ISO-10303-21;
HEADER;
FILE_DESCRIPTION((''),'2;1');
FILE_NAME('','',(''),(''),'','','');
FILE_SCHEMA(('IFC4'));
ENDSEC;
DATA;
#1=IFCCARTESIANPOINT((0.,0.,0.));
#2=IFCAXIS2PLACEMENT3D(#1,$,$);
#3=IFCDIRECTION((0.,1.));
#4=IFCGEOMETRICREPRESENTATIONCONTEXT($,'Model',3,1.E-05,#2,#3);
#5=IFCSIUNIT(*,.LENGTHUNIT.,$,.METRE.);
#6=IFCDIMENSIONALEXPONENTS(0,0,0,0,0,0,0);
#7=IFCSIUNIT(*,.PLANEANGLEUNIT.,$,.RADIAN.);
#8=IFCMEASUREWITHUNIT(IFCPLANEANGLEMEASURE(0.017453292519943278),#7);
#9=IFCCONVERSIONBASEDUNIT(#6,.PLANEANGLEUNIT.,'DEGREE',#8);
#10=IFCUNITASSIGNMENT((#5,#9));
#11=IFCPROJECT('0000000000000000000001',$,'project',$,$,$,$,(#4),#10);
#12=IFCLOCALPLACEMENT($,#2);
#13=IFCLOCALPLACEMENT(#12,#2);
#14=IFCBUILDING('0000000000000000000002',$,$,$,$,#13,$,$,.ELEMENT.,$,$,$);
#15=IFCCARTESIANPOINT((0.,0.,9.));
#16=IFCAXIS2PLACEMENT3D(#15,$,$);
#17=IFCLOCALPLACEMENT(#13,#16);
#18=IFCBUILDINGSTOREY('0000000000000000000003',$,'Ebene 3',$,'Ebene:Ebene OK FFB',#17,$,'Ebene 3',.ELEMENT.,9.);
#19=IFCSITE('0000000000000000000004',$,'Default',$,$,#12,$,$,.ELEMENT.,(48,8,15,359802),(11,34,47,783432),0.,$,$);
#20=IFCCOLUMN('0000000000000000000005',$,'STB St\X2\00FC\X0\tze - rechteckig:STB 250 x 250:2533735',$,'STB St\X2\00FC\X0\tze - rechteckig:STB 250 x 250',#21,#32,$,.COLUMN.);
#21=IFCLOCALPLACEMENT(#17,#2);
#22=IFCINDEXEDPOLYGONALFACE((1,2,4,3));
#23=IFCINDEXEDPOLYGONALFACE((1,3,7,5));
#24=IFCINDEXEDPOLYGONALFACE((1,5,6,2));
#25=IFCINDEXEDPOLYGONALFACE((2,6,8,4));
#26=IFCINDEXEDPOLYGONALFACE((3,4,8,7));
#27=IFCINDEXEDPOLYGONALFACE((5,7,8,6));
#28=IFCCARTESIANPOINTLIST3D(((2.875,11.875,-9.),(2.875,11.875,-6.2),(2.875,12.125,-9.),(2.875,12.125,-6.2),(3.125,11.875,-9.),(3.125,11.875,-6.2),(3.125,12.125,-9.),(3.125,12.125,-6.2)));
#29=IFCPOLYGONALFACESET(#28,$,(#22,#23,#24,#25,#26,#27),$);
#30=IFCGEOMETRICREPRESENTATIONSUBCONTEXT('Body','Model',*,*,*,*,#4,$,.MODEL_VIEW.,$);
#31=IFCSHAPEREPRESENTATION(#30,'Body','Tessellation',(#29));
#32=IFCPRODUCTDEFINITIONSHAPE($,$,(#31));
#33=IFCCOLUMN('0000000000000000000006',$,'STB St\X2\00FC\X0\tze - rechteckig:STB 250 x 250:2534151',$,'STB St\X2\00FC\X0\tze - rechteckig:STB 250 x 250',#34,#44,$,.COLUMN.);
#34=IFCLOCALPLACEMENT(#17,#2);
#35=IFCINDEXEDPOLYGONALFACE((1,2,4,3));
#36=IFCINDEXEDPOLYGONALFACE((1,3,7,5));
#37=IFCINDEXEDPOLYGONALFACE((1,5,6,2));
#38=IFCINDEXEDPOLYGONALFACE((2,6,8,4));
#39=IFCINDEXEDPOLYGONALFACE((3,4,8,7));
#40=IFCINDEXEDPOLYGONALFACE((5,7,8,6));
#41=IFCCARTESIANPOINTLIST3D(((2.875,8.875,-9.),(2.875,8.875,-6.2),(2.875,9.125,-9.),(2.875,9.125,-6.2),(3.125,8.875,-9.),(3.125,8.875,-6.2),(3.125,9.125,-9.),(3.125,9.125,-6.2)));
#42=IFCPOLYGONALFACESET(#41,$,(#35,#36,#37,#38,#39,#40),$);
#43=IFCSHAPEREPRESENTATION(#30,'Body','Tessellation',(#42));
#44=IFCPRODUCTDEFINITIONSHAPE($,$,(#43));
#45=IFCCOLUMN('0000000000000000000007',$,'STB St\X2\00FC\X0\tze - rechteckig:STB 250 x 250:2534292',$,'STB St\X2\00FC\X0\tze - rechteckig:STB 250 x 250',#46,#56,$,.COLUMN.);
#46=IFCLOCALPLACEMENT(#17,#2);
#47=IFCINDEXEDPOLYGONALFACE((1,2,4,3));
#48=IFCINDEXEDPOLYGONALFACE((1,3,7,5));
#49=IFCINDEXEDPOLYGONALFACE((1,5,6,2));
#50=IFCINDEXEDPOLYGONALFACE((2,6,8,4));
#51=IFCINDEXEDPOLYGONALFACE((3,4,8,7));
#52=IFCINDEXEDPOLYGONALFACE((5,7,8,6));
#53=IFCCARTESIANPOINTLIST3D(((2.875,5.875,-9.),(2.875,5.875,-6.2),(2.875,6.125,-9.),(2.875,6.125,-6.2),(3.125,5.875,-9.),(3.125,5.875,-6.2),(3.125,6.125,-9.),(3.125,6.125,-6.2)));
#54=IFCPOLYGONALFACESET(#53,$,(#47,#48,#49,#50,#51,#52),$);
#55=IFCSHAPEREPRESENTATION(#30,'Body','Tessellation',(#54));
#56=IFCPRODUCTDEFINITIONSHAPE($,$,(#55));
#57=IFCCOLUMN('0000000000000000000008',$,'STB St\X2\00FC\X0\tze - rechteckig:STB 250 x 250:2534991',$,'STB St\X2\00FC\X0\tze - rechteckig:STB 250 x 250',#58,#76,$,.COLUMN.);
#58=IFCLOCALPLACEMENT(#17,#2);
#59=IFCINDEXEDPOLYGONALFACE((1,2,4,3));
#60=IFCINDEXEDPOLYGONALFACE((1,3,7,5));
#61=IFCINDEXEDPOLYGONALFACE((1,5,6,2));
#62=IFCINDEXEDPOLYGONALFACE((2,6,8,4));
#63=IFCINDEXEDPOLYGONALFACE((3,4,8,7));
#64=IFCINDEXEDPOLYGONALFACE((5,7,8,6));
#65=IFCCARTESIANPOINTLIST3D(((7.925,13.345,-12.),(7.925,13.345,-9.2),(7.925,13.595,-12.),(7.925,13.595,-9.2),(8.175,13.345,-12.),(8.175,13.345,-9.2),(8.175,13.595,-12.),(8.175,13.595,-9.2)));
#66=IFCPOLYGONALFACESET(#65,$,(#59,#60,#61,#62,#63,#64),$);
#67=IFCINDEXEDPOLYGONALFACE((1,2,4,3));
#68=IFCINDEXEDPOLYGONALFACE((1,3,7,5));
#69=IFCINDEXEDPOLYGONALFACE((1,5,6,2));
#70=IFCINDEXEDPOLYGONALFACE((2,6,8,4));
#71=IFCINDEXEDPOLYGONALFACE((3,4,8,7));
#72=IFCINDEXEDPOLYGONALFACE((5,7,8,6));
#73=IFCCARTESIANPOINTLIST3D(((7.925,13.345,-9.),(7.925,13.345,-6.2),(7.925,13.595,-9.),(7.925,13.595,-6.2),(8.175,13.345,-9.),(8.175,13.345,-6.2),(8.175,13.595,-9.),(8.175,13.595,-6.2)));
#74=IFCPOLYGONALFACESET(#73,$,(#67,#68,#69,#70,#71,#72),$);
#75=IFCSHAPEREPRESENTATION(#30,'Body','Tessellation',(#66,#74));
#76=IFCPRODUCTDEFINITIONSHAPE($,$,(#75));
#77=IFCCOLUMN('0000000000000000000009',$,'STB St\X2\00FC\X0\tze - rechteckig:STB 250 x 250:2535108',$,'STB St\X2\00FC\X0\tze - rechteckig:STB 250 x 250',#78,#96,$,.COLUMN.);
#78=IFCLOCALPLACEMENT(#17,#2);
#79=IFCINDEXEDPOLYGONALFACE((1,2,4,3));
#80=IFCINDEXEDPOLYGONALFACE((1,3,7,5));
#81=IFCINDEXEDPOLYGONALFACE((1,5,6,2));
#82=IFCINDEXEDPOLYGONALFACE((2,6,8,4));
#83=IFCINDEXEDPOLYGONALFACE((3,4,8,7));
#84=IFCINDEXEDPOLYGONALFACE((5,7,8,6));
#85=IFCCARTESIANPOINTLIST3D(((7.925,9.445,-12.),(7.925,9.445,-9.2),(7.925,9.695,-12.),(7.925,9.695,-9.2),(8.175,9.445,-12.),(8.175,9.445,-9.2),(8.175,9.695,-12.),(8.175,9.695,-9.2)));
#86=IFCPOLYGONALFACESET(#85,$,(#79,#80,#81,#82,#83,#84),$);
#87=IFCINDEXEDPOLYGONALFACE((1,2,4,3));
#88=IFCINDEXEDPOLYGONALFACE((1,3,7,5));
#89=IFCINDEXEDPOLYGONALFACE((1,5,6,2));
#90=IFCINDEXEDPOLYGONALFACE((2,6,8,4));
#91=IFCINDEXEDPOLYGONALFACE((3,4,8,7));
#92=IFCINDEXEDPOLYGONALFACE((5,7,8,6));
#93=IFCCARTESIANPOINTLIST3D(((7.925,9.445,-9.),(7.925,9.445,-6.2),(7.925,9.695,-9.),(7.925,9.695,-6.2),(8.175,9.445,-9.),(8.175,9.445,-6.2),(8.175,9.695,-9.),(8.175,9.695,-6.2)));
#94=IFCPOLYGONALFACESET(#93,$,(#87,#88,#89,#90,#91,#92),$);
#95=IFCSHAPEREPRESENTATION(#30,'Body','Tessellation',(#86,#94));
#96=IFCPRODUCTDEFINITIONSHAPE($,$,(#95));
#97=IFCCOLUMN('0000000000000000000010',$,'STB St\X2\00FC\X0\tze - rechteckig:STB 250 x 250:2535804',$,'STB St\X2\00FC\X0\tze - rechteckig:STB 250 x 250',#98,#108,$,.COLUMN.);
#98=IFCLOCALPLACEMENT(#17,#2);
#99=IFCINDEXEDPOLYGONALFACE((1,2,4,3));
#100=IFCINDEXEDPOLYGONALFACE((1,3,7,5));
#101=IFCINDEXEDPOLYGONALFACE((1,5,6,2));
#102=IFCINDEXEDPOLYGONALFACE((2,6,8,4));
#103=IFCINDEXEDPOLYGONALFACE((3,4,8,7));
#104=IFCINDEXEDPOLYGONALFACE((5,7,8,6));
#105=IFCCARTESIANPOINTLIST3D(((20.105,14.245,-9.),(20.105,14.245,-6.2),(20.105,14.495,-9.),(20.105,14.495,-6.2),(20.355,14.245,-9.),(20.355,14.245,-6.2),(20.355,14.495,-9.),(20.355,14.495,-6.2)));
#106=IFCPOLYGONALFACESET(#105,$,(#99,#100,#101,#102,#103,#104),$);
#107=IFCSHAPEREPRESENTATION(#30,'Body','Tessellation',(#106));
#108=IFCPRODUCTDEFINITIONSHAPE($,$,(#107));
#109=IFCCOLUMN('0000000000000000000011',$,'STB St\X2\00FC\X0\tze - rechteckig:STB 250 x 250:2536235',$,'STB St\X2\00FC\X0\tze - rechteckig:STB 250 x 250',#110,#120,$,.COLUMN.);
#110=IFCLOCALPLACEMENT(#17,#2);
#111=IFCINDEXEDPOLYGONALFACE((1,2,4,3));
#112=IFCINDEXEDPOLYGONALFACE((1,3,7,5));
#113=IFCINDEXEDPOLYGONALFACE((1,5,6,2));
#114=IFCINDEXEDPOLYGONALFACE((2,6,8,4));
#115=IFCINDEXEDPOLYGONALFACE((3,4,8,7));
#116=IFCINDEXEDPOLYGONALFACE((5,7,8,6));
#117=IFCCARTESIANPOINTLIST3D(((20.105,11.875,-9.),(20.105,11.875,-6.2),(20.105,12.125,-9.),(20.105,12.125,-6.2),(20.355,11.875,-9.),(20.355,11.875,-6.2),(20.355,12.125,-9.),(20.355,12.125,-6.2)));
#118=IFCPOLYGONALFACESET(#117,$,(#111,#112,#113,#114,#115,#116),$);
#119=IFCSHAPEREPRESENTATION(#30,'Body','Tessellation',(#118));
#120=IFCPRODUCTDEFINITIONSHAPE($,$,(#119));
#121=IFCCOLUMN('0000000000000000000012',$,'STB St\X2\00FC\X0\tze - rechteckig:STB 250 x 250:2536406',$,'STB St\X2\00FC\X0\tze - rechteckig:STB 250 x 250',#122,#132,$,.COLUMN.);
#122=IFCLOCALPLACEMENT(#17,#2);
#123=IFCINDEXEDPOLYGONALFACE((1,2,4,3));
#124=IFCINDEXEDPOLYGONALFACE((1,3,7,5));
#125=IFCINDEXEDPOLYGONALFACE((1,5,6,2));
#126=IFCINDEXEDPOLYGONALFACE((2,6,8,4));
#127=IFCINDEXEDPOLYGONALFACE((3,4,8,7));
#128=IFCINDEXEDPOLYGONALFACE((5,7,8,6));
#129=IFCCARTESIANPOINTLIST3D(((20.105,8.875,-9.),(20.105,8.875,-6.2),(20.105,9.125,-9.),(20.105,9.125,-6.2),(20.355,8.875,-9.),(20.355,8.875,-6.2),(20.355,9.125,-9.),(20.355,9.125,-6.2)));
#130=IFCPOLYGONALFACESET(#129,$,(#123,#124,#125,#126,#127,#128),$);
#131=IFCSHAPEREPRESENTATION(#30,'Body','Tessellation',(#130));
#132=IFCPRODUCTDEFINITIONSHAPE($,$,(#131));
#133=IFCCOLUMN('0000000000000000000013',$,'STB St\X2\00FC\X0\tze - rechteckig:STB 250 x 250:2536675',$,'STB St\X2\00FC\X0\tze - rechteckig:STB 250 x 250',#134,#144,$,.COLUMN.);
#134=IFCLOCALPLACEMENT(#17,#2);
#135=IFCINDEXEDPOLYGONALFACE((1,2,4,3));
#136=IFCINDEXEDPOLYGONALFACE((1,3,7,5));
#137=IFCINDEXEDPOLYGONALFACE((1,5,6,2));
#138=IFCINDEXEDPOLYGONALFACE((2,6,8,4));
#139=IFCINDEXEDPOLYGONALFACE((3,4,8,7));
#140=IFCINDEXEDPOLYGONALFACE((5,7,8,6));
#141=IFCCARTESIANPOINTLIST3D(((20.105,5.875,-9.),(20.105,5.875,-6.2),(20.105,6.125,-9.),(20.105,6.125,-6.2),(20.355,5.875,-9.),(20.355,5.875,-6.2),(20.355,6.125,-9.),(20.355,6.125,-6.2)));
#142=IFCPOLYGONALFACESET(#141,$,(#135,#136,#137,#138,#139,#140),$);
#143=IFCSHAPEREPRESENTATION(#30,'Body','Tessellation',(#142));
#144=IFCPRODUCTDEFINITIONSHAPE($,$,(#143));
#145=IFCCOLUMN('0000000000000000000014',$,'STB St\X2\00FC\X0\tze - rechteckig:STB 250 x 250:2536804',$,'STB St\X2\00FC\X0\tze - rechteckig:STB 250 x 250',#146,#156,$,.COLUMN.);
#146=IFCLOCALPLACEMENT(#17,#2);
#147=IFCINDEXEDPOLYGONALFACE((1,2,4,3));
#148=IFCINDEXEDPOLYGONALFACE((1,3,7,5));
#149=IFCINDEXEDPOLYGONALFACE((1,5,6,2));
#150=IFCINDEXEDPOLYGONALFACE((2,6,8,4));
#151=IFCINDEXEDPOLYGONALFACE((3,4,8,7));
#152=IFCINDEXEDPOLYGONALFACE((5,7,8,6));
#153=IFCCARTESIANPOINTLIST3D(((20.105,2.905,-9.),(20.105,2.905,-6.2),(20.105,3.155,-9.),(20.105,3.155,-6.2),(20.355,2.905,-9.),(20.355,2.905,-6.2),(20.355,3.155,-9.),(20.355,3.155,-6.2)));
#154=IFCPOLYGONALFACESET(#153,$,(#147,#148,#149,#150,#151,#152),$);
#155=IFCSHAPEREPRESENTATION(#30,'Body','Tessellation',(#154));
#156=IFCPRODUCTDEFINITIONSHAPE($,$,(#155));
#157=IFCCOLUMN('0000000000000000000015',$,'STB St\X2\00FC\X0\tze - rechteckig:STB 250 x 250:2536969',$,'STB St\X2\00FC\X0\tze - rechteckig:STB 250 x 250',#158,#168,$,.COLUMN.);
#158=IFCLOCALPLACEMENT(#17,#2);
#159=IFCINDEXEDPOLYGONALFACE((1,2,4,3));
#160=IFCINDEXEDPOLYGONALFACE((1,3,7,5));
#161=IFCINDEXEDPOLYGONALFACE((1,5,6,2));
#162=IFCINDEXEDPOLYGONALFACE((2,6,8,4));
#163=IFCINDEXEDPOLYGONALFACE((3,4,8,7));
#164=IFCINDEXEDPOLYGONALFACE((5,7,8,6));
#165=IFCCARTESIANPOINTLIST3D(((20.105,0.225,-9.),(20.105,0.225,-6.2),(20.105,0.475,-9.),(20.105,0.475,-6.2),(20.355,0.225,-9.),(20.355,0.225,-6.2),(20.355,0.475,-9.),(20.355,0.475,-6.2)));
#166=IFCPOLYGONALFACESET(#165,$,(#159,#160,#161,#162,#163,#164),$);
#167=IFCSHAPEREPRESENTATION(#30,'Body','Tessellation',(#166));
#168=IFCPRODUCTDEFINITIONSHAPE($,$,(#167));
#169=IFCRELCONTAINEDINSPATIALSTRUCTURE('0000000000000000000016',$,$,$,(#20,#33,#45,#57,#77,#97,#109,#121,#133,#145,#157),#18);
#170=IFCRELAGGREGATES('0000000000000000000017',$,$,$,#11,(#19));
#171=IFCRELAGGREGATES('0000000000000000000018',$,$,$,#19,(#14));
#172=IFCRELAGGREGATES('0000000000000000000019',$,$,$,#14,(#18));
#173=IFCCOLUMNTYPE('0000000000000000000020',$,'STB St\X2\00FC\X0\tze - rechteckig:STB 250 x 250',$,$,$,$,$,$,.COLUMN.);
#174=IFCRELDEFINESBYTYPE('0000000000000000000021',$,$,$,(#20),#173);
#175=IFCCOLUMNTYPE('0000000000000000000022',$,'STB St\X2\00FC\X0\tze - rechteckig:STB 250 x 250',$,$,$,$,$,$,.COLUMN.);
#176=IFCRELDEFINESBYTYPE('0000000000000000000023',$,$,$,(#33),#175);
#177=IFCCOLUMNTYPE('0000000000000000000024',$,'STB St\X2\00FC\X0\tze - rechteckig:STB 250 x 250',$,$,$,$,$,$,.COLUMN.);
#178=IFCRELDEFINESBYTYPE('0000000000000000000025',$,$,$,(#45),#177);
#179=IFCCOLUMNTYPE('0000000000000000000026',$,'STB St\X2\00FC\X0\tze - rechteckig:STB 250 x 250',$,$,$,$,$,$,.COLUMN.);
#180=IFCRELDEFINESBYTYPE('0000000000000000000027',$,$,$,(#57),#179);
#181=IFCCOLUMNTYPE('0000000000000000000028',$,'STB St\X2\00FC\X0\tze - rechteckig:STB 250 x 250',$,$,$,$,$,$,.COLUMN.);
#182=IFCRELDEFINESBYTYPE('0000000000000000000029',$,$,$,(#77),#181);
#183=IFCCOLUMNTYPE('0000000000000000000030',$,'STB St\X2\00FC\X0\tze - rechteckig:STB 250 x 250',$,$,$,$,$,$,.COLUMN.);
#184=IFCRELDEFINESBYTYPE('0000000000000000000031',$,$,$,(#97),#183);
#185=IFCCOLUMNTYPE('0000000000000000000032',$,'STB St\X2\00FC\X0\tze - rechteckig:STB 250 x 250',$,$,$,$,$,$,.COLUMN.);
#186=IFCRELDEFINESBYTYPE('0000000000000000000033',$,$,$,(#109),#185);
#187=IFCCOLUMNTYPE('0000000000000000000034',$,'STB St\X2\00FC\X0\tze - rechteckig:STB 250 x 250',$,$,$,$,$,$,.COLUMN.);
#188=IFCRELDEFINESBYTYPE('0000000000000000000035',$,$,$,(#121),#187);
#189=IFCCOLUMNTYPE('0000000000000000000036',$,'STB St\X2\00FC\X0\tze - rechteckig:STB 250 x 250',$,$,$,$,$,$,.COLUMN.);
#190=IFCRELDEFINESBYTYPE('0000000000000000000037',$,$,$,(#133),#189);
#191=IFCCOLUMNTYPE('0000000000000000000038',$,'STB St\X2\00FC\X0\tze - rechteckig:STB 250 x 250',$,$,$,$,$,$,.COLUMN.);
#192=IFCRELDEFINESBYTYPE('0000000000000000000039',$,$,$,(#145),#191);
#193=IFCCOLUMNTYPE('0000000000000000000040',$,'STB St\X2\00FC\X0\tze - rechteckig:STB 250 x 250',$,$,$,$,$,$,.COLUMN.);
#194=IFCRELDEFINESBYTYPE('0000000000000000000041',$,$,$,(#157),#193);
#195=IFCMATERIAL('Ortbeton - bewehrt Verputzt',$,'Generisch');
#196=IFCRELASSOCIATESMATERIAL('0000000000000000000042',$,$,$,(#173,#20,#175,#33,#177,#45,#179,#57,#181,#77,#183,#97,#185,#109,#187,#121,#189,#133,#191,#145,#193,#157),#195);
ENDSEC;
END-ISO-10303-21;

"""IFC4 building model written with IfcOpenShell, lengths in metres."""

from ifc_helpers import new_model, entity, si_unit, converted_unit, direction, frame, origin, place, context, subcontext, project, spatial, indexed_curve, outline, extrude, source, transform, mapped, material, type_object, type_shapes, element, save


model = new_model("IFC4")

# Units and contexts
model_context = context("Model", 3, precision=1e-05, world=origin(), true_north=direction((0.0, 1.0)))
body_context = subcontext(model_context, "Body", "Model", "MODEL_VIEW")
ifc_project = project(units=[si_unit("LENGTHUNIT", "METRE"), converted_unit("PLANEANGLEUNIT", "DEGREE", entity("IfcPlaneAngleMeasure", 0.017453292519943278), si_unit("PLANEANGLEUNIT", "RADIAN"), dimensions=[0, 0, 0, 0, 0, 0, 0])], contexts=[model_context])

# Site, building, storey
site_placement = place(None, origin())
site = spatial("IfcSite", under=ifc_project, at=site_placement, Name="Default", CompositionType="ELEMENT", RefLatitude=(48, 8, 15, 359802), RefLongitude=(11, 34, 47, 783432), RefElevation=0.0)
building_placement = place(site_placement, origin())
building = spatial("IfcBuilding", under=site, at=building_placement, CompositionType="ELEMENT")
storey_placement = place(building_placement, frame((0.0, 0.0, 9.0)))
storey = spatial("IfcBuildingStorey", under=building, at=storey_placement, Name="Ebene 3", ObjectType="Ebene:Ebene OK FFB", LongName="Ebene 3", CompositionType="ELEMENT", Elevation=9.0)

# Columns
ifc_material_1 = material(Name="Ortbeton - bewehrt Verputzt", Category="Generisch")
column_type_1 = type_object("IfcColumnType", Name="STB Stütze - rechteckig:STB 250 x 250", PredefinedType="COLUMN", material=ifc_material_1)
shared_shape_1 = source(origin(), body_context, "Body", "SweptSolid", [
    extrude(outline(indexed_curve([(-0.125, -0.125), (0.125, -0.125), (0.125, 0.125), (-0.125, 0.125), (-0.125, -0.125)], self_intersect=False)), frame((3.0, 12.0, 0.0), z_axis=(0.0, 0.0, 1.0), x_axis=(-1.0, 0.0, 0.0)), (0.0, 0.0, 1.0), 2.8),
])
type_shapes(column_type_1, [shared_shape_1])
column_1_placement = place(storey_placement, frame((0.0, 0.0, -9.0)))
element("IfcColumn", 1, at=column_1_placement, inside=storey, type_object=column_type_1, material=ifc_material_1, Name="STB Stütze - rechteckig:STB 250 x 250:2533735", ObjectType="STB Stütze - rechteckig:STB 250 x 250", PredefinedType="COLUMN", context=body_context, shape_type="MappedRepresentation", body=[
    mapped(shared_shape_1, transform((0.0, 0.0, 0.0), scale=1.0)),
])
column_type_2 = type_object("IfcColumnType", Name="STB Stütze - rechteckig:STB 250 x 250", PredefinedType="COLUMN", material=ifc_material_1)
shared_shape_2 = source(origin(), body_context, "Body", "SweptSolid", [
    extrude(outline(indexed_curve([(-0.125, -0.125), (0.125, -0.125), (0.125, 0.125), (-0.125, 0.125), (-0.125, -0.125)], self_intersect=False)), frame((3.0, 9.0, 0.0), z_axis=(0.0, 0.0, 1.0), x_axis=(-1.0, 0.0, 0.0)), (0.0, 0.0, 1.0), 2.8),
])
type_shapes(column_type_2, [shared_shape_2])
column_2_placement = place(storey_placement, frame((0.0, 0.0, -9.0)))
element("IfcColumn", 2, at=column_2_placement, inside=storey, type_object=column_type_2, material=ifc_material_1, Name="STB Stütze - rechteckig:STB 250 x 250:2534151", ObjectType="STB Stütze - rechteckig:STB 250 x 250", PredefinedType="COLUMN", context=body_context, shape_type="MappedRepresentation", body=[
    mapped(shared_shape_2, transform((0.0, 0.0, 0.0), scale=1.0)),
])
column_type_3 = type_object("IfcColumnType", Name="STB Stütze - rechteckig:STB 250 x 250", PredefinedType="COLUMN", material=ifc_material_1)
shared_shape_3 = source(origin(), body_context, "Body", "SweptSolid", [
    extrude(outline(indexed_curve([(-0.125, -0.125), (0.125, -0.125), (0.125, 0.125), (-0.125, 0.125), (-0.125, -0.125)], self_intersect=False)), frame((3.0, 6.0, 0.0), z_axis=(0.0, 0.0, 1.0), x_axis=(-1.0, 0.0, 0.0)), (0.0, 0.0, 1.0), 2.8),
])
type_shapes(column_type_3, [shared_shape_3])
column_3_placement = place(storey_placement, frame((0.0, 0.0, -9.0)))
element("IfcColumn", 3, at=column_3_placement, inside=storey, type_object=column_type_3, material=ifc_material_1, Name="STB Stütze - rechteckig:STB 250 x 250:2534292", ObjectType="STB Stütze - rechteckig:STB 250 x 250", PredefinedType="COLUMN", context=body_context, shape_type="MappedRepresentation", body=[
    mapped(shared_shape_3, transform((0.0, 0.0, 0.0), scale=1.0)),
])
column_type_4 = type_object("IfcColumnType", Name="STB Stütze - rechteckig:STB 250 x 250", PredefinedType="COLUMN", material=ifc_material_1)
shared_shape_4 = source(origin(), body_context, "Body", "SweptSolid", [
    extrude(outline(indexed_curve([(-0.125, -0.125), (0.125, -0.125), (0.125, 0.125), (-0.125, 0.125), (-0.125, -0.125)], self_intersect=False)), frame((8.05, 13.47, -3.0), z_axis=(0.0, 0.0, 1.0), x_axis=(-1.0, 0.0, 0.0)), (0.0, 0.0, 1.0), 2.8),
    extrude(outline(indexed_curve([(-0.125, -0.125), (0.125, -0.125), (0.125, 0.125), (-0.125, 0.125), (-0.125, -0.125)], self_intersect=False)), frame((8.05, 13.47, 0.0), z_axis=(0.0, 0.0, 1.0), x_axis=(0.0, -1.0, 0.0)), (0.0, 0.0, 1.0), 2.8),
])
type_shapes(column_type_4, [shared_shape_4])
column_4_placement = place(storey_placement, frame((0.0, 0.0, -9.0)))
element("IfcColumn", 4, at=column_4_placement, inside=storey, type_object=column_type_4, material=ifc_material_1, Name="STB Stütze - rechteckig:STB 250 x 250:2534991", ObjectType="STB Stütze - rechteckig:STB 250 x 250", PredefinedType="COLUMN", context=body_context, shape_type="MappedRepresentation", body=[
    mapped(shared_shape_4, transform((0.0, 0.0, 0.0), scale=1.0)),
])
column_type_5 = type_object("IfcColumnType", Name="STB Stütze - rechteckig:STB 250 x 250", PredefinedType="COLUMN", material=ifc_material_1)
shared_shape_5 = source(origin(), body_context, "Body", "SweptSolid", [
    extrude(outline(indexed_curve([(-0.125, -0.125), (0.125, -0.125), (0.125, 0.125), (-0.125, 0.125), (-0.125, -0.125)], self_intersect=False)), frame((8.05, 9.57, -3.0), z_axis=(0.0, 0.0, 1.0), x_axis=(-1.0, 0.0, 0.0)), (0.0, 0.0, 1.0), 2.8),
    extrude(outline(indexed_curve([(-0.125, -0.125), (0.125, -0.125), (0.125, 0.125), (-0.125, 0.125), (-0.125, -0.125)], self_intersect=False)), frame((8.05, 9.57, 0.0), z_axis=(0.0, 0.0, 1.0), x_axis=(0.0, -1.0, 0.0)), (0.0, 0.0, 1.0), 2.8),
])
type_shapes(column_type_5, [shared_shape_5])
column_5_placement = place(storey_placement, frame((0.0, 0.0, -9.0)))
element("IfcColumn", 5, at=column_5_placement, inside=storey, type_object=column_type_5, material=ifc_material_1, Name="STB Stütze - rechteckig:STB 250 x 250:2535108", ObjectType="STB Stütze - rechteckig:STB 250 x 250", PredefinedType="COLUMN", context=body_context, shape_type="MappedRepresentation", body=[
    mapped(shared_shape_5, transform((0.0, 0.0, 0.0), scale=1.0)),
])
column_type_6 = type_object("IfcColumnType", Name="STB Stütze - rechteckig:STB 250 x 250", PredefinedType="COLUMN", material=ifc_material_1)
shared_shape_6 = source(origin(), body_context, "Body", "SweptSolid", [
    extrude(outline(indexed_curve([(-0.125, -0.125), (0.125, -0.125), (0.125, 0.125), (-0.125, 0.125), (-0.125, -0.125)], self_intersect=False)), frame((20.23, 14.37, 0.0), z_axis=(0.0, 0.0, 1.0), x_axis=(-1.0, 0.0, 0.0)), (0.0, 0.0, 1.0), 2.8),
])
type_shapes(column_type_6, [shared_shape_6])
column_6_placement = place(storey_placement, frame((0.0, 0.0, -9.0)))
element("IfcColumn", 6, at=column_6_placement, inside=storey, type_object=column_type_6, material=ifc_material_1, Name="STB Stütze - rechteckig:STB 250 x 250:2535804", ObjectType="STB Stütze - rechteckig:STB 250 x 250", PredefinedType="COLUMN", context=body_context, shape_type="MappedRepresentation", body=[
    mapped(shared_shape_6, transform((0.0, 0.0, 0.0), scale=1.0)),
])
column_type_7 = type_object("IfcColumnType", Name="STB Stütze - rechteckig:STB 250 x 250", PredefinedType="COLUMN", material=ifc_material_1)
shared_shape_7 = source(origin(), body_context, "Body", "SweptSolid", [
    extrude(outline(indexed_curve([(-0.125, -0.125), (0.125, -0.125), (0.125, 0.125), (-0.125, 0.125), (-0.125, -0.125)], self_intersect=False)), frame((20.23, 12.0, 0.0), z_axis=(0.0, 0.0, 1.0), x_axis=(-1.0, 0.0, 0.0)), (0.0, 0.0, 1.0), 2.8),
])
type_shapes(column_type_7, [shared_shape_7])
column_7_placement = place(storey_placement, frame((0.0, 0.0, -9.0)))
element("IfcColumn", 7, at=column_7_placement, inside=storey, type_object=column_type_7, material=ifc_material_1, Name="STB Stütze - rechteckig:STB 250 x 250:2536235", ObjectType="STB Stütze - rechteckig:STB 250 x 250", PredefinedType="COLUMN", context=body_context, shape_type="MappedRepresentation", body=[
    mapped(shared_shape_7, transform((0.0, 0.0, 0.0), scale=1.0)),
])
column_type_8 = type_object("IfcColumnType", Name="STB Stütze - rechteckig:STB 250 x 250", PredefinedType="COLUMN", material=ifc_material_1)
shared_shape_8 = source(origin(), body_context, "Body", "SweptSolid", [
    extrude(outline(indexed_curve([(-0.125, -0.125), (0.125, -0.125), (0.125, 0.125), (-0.125, 0.125), (-0.125, -0.125)], self_intersect=False)), frame((20.23, 9.0, 0.0), z_axis=(0.0, 0.0, 1.0), x_axis=(-1.0, 0.0, 0.0)), (0.0, 0.0, 1.0), 2.8),
])
type_shapes(column_type_8, [shared_shape_8])
column_8_placement = place(storey_placement, frame((0.0, 0.0, -9.0)))
element("IfcColumn", 8, at=column_8_placement, inside=storey, type_object=column_type_8, material=ifc_material_1, Name="STB Stütze - rechteckig:STB 250 x 250:2536406", ObjectType="STB Stütze - rechteckig:STB 250 x 250", PredefinedType="COLUMN", context=body_context, shape_type="MappedRepresentation", body=[
    mapped(shared_shape_8, transform((0.0, 0.0, 0.0), scale=1.0)),
])
column_type_9 = type_object("IfcColumnType", Name="STB Stütze - rechteckig:STB 250 x 250", PredefinedType="COLUMN", material=ifc_material_1)
shared_shape_9 = source(origin(), body_context, "Body", "SweptSolid", [
    extrude(outline(indexed_curve([(-0.125, -0.125), (0.125, -0.125), (0.125, 0.125), (-0.125, 0.125), (-0.125, -0.125)], self_intersect=False)), frame((20.23, 6.0, 0.0), z_axis=(0.0, 0.0, 1.0), x_axis=(-1.0, 0.0, 0.0)), (0.0, 0.0, 1.0), 2.8),
])
type_shapes(column_type_9, [shared_shape_9])
column_9_placement = place(storey_placement, frame((0.0, 0.0, -9.0)))
element("IfcColumn", 9, at=column_9_placement, inside=storey, type_object=column_type_9, material=ifc_material_1, Name="STB Stütze - rechteckig:STB 250 x 250:2536675", ObjectType="STB Stütze - rechteckig:STB 250 x 250", PredefinedType="COLUMN", context=body_context, shape_type="MappedRepresentation", body=[
    mapped(shared_shape_9, transform((0.0, 0.0, 0.0), scale=1.0)),
])
column_type_10 = type_object("IfcColumnType", Name="STB Stütze - rechteckig:STB 250 x 250", PredefinedType="COLUMN", material=ifc_material_1)
shared_shape_10 = source(origin(), body_context, "Body", "SweptSolid", [
    extrude(outline(indexed_curve([(-0.125, -0.125), (0.125, -0.125), (0.125, 0.125), (-0.125, 0.125), (-0.125, -0.125)], self_intersect=False)), frame((20.23, 3.03, 0.0), z_axis=(0.0, 0.0, 1.0), x_axis=(-1.0, 0.0, 0.0)), (0.0, 0.0, 1.0), 2.8),
])
type_shapes(column_type_10, [shared_shape_10])
column_10_placement = place(storey_placement, frame((0.0, 0.0, -9.0)))
element("IfcColumn", 10, at=column_10_placement, inside=storey, type_object=column_type_10, material=ifc_material_1, Name="STB Stütze - rechteckig:STB 250 x 250:2536804", ObjectType="STB Stütze - rechteckig:STB 250 x 250", PredefinedType="COLUMN", context=body_context, shape_type="MappedRepresentation", body=[
    mapped(shared_shape_10, transform((0.0, 0.0, 0.0), scale=1.0)),
])
column_type_11 = type_object("IfcColumnType", Name="STB Stütze - rechteckig:STB 250 x 250", PredefinedType="COLUMN", material=ifc_material_1)
shared_shape_11 = source(origin(), body_context, "Body", "SweptSolid", [
    extrude(outline(indexed_curve([(-0.125, -0.125), (0.125, -0.125), (0.125, 0.125), (-0.125, 0.125), (-0.125, -0.125)], self_intersect=False)), frame((20.23, 0.35, 0.0), z_axis=(0.0, 0.0, 1.0), x_axis=(-1.0, 0.0, 0.0)), (0.0, 0.0, 1.0), 2.8),
])
type_shapes(column_type_11, [shared_shape_11])
column_11_placement = place(storey_placement, frame((0.0, 0.0, -9.0)))
element("IfcColumn", 11, at=column_11_placement, inside=storey, type_object=column_type_11, material=ifc_material_1, Name="STB Stütze - rechteckig:STB 250 x 250:2536969", ObjectType="STB Stütze - rechteckig:STB 250 x 250", PredefinedType="COLUMN", context=body_context, shape_type="MappedRepresentation", body=[
    mapped(shared_shape_11, transform((0.0, 0.0, 0.0), scale=1.0)),
])

save(model, "model.ifc")
